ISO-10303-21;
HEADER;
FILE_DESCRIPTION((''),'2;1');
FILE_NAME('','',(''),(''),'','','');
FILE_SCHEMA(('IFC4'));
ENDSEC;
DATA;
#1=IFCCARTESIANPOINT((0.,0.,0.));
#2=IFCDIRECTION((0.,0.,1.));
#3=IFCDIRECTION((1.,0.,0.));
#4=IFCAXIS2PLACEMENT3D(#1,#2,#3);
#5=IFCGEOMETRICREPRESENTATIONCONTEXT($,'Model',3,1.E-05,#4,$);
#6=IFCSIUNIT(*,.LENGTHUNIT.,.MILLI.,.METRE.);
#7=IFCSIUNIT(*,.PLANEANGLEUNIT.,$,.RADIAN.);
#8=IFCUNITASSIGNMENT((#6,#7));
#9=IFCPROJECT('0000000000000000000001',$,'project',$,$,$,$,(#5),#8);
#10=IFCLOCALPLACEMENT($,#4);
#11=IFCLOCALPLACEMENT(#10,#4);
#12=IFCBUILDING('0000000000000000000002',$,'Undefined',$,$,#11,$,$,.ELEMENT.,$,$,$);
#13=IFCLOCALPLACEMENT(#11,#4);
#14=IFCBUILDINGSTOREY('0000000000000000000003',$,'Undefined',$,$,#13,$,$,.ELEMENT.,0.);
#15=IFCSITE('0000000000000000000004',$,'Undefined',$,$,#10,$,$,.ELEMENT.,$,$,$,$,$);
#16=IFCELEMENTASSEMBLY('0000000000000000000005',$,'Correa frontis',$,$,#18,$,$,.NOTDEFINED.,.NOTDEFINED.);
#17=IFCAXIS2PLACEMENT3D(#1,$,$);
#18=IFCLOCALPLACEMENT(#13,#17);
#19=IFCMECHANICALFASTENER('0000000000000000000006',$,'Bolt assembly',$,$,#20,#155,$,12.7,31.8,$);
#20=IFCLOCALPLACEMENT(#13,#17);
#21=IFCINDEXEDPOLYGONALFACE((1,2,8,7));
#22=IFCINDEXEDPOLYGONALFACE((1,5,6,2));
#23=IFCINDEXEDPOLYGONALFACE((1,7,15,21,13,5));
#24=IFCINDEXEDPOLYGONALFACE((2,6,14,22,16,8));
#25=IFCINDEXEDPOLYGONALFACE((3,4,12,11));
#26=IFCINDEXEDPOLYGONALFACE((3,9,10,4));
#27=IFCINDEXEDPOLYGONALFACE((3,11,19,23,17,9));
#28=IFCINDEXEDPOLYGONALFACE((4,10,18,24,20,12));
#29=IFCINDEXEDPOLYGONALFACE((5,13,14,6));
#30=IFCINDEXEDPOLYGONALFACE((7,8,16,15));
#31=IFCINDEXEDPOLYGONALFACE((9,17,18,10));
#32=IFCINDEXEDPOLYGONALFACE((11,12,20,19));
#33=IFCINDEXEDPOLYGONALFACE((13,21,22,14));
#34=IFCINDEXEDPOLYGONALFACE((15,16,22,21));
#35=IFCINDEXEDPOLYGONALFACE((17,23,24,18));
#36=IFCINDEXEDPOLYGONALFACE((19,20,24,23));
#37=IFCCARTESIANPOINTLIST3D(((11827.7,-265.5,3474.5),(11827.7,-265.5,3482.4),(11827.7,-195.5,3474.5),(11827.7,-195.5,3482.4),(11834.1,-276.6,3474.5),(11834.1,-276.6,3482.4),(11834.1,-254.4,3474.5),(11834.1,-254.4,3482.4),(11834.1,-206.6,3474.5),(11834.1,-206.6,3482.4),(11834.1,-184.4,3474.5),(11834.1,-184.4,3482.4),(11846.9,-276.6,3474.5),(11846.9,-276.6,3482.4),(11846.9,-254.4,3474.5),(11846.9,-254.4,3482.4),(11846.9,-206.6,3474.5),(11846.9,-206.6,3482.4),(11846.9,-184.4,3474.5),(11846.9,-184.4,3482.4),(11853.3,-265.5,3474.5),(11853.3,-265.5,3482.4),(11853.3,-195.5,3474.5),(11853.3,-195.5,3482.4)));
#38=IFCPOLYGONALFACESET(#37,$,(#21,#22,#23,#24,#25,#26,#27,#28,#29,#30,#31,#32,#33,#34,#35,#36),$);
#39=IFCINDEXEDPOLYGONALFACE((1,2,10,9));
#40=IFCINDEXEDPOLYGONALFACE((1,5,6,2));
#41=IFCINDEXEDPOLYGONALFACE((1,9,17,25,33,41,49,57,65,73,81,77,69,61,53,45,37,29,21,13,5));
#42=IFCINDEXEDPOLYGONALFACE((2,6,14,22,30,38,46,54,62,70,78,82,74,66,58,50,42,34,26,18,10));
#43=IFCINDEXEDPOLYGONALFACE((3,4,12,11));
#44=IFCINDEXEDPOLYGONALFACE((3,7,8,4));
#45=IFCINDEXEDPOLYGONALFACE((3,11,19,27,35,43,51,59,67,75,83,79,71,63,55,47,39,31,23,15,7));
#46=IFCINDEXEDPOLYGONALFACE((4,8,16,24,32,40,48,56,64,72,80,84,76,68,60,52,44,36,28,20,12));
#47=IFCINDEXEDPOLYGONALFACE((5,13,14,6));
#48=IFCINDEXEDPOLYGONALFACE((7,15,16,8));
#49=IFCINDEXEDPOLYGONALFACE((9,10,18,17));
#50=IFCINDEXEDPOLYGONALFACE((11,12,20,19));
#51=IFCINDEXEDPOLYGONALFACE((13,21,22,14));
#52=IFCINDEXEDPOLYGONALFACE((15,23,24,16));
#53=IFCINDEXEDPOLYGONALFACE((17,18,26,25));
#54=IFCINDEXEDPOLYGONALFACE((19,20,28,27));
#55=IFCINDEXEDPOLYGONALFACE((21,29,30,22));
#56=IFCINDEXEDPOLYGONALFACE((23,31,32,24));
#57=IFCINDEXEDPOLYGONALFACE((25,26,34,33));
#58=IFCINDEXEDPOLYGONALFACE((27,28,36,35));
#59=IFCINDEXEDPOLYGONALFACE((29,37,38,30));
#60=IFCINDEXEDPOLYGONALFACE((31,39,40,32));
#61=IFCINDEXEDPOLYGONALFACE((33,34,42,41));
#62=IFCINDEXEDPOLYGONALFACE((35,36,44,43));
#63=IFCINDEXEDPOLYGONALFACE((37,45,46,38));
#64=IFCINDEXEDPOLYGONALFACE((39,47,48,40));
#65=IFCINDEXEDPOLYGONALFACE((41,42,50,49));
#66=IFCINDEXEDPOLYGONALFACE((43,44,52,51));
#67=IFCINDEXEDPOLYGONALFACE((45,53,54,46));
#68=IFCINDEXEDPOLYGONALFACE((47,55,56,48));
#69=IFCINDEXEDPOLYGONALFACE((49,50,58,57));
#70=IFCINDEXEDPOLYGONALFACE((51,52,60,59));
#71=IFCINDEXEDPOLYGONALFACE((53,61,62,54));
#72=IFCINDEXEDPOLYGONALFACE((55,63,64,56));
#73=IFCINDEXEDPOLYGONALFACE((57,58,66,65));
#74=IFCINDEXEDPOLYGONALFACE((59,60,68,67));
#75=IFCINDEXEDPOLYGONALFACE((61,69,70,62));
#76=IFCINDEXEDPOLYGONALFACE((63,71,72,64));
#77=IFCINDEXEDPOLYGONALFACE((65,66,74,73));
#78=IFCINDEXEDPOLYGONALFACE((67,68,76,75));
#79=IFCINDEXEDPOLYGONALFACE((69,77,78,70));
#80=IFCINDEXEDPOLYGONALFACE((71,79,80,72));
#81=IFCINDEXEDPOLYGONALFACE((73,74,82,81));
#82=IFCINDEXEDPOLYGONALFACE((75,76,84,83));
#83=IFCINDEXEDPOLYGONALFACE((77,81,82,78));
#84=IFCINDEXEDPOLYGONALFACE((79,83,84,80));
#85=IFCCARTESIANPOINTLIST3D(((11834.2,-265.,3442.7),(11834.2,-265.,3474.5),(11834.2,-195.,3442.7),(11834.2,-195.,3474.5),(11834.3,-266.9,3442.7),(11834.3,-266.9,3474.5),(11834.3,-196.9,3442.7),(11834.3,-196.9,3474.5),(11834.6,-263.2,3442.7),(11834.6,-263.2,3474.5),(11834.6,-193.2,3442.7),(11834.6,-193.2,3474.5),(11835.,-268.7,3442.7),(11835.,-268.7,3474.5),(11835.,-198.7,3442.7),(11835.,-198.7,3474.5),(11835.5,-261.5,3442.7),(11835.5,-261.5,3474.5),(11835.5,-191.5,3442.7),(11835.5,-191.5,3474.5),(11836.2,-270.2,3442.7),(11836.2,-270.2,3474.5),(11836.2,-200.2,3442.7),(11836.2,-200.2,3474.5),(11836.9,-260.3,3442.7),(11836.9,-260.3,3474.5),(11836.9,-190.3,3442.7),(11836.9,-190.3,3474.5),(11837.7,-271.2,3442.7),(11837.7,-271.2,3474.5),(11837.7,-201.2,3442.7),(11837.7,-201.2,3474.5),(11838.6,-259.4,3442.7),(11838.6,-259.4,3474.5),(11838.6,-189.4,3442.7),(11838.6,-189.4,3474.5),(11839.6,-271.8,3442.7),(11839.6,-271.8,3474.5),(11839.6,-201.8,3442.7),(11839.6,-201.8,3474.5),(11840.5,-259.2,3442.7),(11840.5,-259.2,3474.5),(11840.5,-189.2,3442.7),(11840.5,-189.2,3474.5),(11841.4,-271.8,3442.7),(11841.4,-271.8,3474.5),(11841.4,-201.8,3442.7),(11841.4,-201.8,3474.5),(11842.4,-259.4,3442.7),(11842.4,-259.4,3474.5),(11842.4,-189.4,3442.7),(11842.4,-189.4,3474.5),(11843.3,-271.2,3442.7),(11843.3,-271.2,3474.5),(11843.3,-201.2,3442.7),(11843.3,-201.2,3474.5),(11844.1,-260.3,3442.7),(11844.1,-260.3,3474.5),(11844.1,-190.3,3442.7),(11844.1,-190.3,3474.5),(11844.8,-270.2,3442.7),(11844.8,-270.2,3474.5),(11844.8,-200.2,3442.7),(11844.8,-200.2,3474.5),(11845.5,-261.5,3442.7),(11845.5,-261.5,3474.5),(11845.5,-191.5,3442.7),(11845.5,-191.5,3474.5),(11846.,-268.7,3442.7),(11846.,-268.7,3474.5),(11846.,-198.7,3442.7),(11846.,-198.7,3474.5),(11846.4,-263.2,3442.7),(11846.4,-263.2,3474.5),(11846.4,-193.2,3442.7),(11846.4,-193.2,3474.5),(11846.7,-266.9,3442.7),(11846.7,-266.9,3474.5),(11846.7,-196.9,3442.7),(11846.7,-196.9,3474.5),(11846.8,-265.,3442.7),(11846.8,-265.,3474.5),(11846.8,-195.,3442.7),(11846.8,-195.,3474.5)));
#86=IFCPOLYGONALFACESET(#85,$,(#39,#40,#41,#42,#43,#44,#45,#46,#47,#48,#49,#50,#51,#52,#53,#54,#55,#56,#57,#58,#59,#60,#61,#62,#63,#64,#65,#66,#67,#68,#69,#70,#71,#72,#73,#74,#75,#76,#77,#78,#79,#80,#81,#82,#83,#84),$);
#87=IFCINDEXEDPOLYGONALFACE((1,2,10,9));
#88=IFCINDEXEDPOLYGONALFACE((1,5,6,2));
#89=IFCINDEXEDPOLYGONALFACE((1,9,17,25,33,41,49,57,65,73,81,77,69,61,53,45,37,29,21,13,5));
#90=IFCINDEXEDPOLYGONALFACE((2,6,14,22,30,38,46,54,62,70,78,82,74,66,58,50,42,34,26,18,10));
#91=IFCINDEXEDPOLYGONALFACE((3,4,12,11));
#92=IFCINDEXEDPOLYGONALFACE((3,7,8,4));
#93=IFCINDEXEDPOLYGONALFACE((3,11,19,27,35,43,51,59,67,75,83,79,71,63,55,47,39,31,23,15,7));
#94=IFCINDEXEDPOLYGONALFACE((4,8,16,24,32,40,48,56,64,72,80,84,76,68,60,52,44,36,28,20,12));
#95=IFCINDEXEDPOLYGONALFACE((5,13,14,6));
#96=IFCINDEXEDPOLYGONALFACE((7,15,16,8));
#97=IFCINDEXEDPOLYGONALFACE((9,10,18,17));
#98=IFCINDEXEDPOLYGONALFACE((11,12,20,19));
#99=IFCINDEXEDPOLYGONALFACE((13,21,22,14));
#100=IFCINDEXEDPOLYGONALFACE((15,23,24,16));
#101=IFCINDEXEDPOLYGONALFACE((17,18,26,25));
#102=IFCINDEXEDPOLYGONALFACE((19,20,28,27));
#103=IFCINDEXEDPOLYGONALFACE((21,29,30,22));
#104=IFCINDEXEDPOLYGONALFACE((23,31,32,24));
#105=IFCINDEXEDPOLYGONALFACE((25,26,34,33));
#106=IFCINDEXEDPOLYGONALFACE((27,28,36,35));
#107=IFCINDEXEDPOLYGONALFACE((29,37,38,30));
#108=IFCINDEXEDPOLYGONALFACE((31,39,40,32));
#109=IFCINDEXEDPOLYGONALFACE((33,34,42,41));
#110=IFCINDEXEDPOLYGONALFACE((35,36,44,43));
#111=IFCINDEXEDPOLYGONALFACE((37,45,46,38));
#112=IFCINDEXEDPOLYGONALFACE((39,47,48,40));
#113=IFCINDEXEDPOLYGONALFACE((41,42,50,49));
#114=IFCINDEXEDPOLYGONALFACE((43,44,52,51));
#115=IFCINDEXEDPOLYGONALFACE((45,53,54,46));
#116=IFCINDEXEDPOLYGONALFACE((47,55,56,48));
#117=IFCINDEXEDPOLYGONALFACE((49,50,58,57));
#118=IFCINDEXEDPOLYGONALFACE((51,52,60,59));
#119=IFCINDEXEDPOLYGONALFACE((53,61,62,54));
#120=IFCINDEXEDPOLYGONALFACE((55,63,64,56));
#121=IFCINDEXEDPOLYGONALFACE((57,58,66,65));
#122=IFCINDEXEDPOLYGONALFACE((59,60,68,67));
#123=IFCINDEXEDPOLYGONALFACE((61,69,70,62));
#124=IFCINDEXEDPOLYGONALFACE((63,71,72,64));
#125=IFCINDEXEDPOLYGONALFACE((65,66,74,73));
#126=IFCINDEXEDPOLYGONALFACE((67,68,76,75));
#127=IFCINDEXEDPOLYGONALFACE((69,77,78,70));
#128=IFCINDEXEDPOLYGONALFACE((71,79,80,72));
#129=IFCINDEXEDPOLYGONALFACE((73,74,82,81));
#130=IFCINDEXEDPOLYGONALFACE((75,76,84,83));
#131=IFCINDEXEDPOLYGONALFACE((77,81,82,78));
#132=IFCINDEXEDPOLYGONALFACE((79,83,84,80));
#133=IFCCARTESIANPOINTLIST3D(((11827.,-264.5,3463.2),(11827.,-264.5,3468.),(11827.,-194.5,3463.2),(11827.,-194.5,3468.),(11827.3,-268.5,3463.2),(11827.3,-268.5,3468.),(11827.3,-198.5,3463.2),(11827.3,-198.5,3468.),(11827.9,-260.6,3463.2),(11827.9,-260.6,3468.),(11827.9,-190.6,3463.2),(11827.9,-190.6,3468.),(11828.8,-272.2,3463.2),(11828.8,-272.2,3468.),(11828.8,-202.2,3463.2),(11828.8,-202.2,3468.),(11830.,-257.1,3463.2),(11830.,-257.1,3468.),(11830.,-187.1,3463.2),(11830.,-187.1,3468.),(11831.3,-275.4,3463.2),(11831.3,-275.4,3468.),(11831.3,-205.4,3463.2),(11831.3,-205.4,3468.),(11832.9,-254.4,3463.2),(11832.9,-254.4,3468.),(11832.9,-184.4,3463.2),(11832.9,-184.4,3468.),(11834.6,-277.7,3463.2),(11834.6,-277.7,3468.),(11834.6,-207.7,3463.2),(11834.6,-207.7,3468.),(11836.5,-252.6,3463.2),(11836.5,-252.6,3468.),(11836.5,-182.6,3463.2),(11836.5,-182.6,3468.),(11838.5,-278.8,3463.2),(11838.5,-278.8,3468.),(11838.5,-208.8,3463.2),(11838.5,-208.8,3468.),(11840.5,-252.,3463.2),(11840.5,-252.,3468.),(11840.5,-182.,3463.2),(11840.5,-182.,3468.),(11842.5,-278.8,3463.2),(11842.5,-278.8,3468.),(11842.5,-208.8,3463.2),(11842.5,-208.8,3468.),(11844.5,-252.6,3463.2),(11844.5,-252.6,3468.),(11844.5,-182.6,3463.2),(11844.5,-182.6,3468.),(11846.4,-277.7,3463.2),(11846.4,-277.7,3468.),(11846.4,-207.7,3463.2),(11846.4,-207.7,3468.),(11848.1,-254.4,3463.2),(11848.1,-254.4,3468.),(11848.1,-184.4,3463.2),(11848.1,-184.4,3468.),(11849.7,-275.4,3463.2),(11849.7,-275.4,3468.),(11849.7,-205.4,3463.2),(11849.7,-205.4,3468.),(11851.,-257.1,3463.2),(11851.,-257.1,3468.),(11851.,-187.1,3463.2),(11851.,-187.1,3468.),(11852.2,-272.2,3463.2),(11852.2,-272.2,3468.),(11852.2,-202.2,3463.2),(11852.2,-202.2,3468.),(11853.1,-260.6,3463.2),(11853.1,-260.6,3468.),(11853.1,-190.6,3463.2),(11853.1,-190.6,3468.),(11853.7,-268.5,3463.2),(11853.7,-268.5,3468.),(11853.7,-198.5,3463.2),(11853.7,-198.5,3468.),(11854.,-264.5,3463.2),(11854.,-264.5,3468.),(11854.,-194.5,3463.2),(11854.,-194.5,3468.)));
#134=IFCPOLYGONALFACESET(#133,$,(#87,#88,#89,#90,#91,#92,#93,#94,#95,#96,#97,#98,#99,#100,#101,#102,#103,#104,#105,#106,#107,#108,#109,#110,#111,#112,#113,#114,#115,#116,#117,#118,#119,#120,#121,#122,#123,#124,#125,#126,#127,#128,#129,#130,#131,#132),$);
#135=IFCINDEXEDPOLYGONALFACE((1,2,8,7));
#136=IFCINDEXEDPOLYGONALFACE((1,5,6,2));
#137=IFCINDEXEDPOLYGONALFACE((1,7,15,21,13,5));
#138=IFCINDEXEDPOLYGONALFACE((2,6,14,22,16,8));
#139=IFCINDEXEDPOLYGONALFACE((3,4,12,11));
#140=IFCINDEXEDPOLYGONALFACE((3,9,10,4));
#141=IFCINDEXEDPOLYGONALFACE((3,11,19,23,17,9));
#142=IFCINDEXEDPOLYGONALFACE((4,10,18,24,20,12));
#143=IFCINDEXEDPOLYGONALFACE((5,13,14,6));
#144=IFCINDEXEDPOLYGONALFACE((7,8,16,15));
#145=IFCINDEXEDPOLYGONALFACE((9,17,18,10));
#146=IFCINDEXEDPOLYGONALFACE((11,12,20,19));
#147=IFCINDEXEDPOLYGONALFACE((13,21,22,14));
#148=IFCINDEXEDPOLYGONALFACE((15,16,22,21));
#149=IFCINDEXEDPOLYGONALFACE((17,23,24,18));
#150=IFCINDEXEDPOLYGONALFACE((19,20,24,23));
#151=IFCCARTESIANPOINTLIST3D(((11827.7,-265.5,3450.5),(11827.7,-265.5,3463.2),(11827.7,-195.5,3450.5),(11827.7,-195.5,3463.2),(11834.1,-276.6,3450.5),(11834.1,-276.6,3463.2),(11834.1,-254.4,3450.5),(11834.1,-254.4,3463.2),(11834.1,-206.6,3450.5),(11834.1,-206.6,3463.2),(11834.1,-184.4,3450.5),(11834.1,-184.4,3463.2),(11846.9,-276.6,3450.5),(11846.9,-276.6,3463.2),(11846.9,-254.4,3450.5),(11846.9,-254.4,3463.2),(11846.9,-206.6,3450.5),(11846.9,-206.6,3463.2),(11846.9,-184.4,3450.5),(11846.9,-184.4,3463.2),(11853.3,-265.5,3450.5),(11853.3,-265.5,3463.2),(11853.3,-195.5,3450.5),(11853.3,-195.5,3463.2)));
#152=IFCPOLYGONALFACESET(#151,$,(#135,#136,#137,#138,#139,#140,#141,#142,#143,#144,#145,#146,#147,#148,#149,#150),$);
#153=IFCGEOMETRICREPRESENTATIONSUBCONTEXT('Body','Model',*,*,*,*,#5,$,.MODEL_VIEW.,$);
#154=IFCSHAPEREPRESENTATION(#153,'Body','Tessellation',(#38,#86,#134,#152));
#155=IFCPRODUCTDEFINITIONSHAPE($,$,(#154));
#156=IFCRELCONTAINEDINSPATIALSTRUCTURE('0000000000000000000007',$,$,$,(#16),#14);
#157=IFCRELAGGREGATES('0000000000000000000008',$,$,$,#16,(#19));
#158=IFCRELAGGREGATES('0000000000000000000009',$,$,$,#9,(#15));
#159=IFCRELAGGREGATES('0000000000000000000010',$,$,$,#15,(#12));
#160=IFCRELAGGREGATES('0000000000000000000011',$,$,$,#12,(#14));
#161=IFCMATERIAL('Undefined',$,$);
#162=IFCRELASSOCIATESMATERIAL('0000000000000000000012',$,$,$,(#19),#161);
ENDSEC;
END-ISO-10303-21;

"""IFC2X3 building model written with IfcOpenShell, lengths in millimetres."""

from ifc_helpers import new_model, si_unit, frame, origin_with_axes, origin_2d_with_axis, place, context, subcontext, project, spatial, polyline, circle, outline, extrude, source, transform, mapped, material, element, aggregate, save


model = new_model("IFC2X3")

# Units and contexts
model_context = context("Model", 3, precision=1e-05, world=origin_with_axes())
body_context = subcontext(model_context, "Body", "Model", "MODEL_VIEW")
ifc_project = project(units=[si_unit("LENGTHUNIT", "METRE", prefix="MILLI"), si_unit("PLANEANGLEUNIT", "RADIAN")], contexts=[model_context])

# Site, building, storey
site_placement = place(None, origin_with_axes())
site = spatial("IfcSite", under=ifc_project, at=site_placement, Name="Undefined", CompositionType="ELEMENT")
building_placement = place(site_placement, origin_with_axes())
building = spatial("IfcBuilding", under=site, at=building_placement, Name="Undefined", CompositionType="ELEMENT")
storey_placement = place(building_placement, origin_with_axes())
storey = spatial("IfcBuildingStorey", under=building, at=storey_placement, Name="Undefined", CompositionType="ELEMENT", Elevation=0.0)

# Element assembly
assembly_1_placement = place(storey_placement, origin_with_axes())
assembly_1 = element("IfcElementAssembly", 1, at=assembly_1_placement, inside=storey, Name="Correa frontis", AssemblyPlace="NOTDEFINED", PredefinedType="NOTDEFINED")

# Mechanical fastener
ifc_material_1 = material(Name="Undefined")
shared_shape_1 = source(origin_with_axes(), body_context, "Body", "SweptSolid", [
    extrude(outline(polyline([(11.1, -6.4), (11.1, 6.4), (0.0, 12.8), (-11.1, 6.4), (-11.1, -6.4), (0.0, -12.8), (11.1, -6.4)])), frame((0.0, -12.4, 0.0), z_axis=(0.0, 1.0, 0.0), x_axis=(1.0, 0.0, 0.0)), (0.0, 0.0, 1.0), 7.9),
    extrude(circle(Radius=6.3, at=origin_2d_with_axis()), frame((0.0, -4.5, 0.0), z_axis=(0.0, 1.0, 0.0), x_axis=(1.0, 0.0, 0.0)), (0.0, 0.0, 1.0), 31.8),
    extrude(circle(Radius=13.5, at=origin_2d_with_axis()), frame((0.0, 2.0, 0.0), z_axis=(0.0, 1.0, 0.0), x_axis=(1.0, 0.0, 0.0)), (0.0, 0.0, 1.0), 4.8),
    extrude(outline(polyline([(11.1, -6.4), (11.1, 6.4), (0.0, 12.8), (-11.1, 6.4), (-11.1, -6.4), (0.0, -12.8), (11.1, -6.4)])), frame((0.0, 6.8, 0.0), z_axis=(0.0, 1.0, 0.0), x_axis=(1.0, 0.0, 0.0)), (0.0, 0.0, 1.0), 12.7),
])
mechanical_fastener_1_placement = place(assembly_1_placement, frame((11840.5, -265.5, 3470.0), z_axis=(-1.0, 0.0, 0.0), x_axis=(0.0, 1.0, 0.0)))
mechanical_fastener_1 = element("IfcMechanicalFastener", 2, at=mechanical_fastener_1_placement, material=ifc_material_1, Name="Bolt assembly", NominalDiameter=12.7, NominalLength=31.8, context=body_context, shape_type="MappedRepresentation", body=[
    mapped(shared_shape_1, transform((0.0, 0.0, 0.0))),
    mapped(shared_shape_1, transform((70.0, 0.0, 0.0))),
])
aggregate(assembly_1, [mechanical_fastener_1])

save(model, "model.ifc")
